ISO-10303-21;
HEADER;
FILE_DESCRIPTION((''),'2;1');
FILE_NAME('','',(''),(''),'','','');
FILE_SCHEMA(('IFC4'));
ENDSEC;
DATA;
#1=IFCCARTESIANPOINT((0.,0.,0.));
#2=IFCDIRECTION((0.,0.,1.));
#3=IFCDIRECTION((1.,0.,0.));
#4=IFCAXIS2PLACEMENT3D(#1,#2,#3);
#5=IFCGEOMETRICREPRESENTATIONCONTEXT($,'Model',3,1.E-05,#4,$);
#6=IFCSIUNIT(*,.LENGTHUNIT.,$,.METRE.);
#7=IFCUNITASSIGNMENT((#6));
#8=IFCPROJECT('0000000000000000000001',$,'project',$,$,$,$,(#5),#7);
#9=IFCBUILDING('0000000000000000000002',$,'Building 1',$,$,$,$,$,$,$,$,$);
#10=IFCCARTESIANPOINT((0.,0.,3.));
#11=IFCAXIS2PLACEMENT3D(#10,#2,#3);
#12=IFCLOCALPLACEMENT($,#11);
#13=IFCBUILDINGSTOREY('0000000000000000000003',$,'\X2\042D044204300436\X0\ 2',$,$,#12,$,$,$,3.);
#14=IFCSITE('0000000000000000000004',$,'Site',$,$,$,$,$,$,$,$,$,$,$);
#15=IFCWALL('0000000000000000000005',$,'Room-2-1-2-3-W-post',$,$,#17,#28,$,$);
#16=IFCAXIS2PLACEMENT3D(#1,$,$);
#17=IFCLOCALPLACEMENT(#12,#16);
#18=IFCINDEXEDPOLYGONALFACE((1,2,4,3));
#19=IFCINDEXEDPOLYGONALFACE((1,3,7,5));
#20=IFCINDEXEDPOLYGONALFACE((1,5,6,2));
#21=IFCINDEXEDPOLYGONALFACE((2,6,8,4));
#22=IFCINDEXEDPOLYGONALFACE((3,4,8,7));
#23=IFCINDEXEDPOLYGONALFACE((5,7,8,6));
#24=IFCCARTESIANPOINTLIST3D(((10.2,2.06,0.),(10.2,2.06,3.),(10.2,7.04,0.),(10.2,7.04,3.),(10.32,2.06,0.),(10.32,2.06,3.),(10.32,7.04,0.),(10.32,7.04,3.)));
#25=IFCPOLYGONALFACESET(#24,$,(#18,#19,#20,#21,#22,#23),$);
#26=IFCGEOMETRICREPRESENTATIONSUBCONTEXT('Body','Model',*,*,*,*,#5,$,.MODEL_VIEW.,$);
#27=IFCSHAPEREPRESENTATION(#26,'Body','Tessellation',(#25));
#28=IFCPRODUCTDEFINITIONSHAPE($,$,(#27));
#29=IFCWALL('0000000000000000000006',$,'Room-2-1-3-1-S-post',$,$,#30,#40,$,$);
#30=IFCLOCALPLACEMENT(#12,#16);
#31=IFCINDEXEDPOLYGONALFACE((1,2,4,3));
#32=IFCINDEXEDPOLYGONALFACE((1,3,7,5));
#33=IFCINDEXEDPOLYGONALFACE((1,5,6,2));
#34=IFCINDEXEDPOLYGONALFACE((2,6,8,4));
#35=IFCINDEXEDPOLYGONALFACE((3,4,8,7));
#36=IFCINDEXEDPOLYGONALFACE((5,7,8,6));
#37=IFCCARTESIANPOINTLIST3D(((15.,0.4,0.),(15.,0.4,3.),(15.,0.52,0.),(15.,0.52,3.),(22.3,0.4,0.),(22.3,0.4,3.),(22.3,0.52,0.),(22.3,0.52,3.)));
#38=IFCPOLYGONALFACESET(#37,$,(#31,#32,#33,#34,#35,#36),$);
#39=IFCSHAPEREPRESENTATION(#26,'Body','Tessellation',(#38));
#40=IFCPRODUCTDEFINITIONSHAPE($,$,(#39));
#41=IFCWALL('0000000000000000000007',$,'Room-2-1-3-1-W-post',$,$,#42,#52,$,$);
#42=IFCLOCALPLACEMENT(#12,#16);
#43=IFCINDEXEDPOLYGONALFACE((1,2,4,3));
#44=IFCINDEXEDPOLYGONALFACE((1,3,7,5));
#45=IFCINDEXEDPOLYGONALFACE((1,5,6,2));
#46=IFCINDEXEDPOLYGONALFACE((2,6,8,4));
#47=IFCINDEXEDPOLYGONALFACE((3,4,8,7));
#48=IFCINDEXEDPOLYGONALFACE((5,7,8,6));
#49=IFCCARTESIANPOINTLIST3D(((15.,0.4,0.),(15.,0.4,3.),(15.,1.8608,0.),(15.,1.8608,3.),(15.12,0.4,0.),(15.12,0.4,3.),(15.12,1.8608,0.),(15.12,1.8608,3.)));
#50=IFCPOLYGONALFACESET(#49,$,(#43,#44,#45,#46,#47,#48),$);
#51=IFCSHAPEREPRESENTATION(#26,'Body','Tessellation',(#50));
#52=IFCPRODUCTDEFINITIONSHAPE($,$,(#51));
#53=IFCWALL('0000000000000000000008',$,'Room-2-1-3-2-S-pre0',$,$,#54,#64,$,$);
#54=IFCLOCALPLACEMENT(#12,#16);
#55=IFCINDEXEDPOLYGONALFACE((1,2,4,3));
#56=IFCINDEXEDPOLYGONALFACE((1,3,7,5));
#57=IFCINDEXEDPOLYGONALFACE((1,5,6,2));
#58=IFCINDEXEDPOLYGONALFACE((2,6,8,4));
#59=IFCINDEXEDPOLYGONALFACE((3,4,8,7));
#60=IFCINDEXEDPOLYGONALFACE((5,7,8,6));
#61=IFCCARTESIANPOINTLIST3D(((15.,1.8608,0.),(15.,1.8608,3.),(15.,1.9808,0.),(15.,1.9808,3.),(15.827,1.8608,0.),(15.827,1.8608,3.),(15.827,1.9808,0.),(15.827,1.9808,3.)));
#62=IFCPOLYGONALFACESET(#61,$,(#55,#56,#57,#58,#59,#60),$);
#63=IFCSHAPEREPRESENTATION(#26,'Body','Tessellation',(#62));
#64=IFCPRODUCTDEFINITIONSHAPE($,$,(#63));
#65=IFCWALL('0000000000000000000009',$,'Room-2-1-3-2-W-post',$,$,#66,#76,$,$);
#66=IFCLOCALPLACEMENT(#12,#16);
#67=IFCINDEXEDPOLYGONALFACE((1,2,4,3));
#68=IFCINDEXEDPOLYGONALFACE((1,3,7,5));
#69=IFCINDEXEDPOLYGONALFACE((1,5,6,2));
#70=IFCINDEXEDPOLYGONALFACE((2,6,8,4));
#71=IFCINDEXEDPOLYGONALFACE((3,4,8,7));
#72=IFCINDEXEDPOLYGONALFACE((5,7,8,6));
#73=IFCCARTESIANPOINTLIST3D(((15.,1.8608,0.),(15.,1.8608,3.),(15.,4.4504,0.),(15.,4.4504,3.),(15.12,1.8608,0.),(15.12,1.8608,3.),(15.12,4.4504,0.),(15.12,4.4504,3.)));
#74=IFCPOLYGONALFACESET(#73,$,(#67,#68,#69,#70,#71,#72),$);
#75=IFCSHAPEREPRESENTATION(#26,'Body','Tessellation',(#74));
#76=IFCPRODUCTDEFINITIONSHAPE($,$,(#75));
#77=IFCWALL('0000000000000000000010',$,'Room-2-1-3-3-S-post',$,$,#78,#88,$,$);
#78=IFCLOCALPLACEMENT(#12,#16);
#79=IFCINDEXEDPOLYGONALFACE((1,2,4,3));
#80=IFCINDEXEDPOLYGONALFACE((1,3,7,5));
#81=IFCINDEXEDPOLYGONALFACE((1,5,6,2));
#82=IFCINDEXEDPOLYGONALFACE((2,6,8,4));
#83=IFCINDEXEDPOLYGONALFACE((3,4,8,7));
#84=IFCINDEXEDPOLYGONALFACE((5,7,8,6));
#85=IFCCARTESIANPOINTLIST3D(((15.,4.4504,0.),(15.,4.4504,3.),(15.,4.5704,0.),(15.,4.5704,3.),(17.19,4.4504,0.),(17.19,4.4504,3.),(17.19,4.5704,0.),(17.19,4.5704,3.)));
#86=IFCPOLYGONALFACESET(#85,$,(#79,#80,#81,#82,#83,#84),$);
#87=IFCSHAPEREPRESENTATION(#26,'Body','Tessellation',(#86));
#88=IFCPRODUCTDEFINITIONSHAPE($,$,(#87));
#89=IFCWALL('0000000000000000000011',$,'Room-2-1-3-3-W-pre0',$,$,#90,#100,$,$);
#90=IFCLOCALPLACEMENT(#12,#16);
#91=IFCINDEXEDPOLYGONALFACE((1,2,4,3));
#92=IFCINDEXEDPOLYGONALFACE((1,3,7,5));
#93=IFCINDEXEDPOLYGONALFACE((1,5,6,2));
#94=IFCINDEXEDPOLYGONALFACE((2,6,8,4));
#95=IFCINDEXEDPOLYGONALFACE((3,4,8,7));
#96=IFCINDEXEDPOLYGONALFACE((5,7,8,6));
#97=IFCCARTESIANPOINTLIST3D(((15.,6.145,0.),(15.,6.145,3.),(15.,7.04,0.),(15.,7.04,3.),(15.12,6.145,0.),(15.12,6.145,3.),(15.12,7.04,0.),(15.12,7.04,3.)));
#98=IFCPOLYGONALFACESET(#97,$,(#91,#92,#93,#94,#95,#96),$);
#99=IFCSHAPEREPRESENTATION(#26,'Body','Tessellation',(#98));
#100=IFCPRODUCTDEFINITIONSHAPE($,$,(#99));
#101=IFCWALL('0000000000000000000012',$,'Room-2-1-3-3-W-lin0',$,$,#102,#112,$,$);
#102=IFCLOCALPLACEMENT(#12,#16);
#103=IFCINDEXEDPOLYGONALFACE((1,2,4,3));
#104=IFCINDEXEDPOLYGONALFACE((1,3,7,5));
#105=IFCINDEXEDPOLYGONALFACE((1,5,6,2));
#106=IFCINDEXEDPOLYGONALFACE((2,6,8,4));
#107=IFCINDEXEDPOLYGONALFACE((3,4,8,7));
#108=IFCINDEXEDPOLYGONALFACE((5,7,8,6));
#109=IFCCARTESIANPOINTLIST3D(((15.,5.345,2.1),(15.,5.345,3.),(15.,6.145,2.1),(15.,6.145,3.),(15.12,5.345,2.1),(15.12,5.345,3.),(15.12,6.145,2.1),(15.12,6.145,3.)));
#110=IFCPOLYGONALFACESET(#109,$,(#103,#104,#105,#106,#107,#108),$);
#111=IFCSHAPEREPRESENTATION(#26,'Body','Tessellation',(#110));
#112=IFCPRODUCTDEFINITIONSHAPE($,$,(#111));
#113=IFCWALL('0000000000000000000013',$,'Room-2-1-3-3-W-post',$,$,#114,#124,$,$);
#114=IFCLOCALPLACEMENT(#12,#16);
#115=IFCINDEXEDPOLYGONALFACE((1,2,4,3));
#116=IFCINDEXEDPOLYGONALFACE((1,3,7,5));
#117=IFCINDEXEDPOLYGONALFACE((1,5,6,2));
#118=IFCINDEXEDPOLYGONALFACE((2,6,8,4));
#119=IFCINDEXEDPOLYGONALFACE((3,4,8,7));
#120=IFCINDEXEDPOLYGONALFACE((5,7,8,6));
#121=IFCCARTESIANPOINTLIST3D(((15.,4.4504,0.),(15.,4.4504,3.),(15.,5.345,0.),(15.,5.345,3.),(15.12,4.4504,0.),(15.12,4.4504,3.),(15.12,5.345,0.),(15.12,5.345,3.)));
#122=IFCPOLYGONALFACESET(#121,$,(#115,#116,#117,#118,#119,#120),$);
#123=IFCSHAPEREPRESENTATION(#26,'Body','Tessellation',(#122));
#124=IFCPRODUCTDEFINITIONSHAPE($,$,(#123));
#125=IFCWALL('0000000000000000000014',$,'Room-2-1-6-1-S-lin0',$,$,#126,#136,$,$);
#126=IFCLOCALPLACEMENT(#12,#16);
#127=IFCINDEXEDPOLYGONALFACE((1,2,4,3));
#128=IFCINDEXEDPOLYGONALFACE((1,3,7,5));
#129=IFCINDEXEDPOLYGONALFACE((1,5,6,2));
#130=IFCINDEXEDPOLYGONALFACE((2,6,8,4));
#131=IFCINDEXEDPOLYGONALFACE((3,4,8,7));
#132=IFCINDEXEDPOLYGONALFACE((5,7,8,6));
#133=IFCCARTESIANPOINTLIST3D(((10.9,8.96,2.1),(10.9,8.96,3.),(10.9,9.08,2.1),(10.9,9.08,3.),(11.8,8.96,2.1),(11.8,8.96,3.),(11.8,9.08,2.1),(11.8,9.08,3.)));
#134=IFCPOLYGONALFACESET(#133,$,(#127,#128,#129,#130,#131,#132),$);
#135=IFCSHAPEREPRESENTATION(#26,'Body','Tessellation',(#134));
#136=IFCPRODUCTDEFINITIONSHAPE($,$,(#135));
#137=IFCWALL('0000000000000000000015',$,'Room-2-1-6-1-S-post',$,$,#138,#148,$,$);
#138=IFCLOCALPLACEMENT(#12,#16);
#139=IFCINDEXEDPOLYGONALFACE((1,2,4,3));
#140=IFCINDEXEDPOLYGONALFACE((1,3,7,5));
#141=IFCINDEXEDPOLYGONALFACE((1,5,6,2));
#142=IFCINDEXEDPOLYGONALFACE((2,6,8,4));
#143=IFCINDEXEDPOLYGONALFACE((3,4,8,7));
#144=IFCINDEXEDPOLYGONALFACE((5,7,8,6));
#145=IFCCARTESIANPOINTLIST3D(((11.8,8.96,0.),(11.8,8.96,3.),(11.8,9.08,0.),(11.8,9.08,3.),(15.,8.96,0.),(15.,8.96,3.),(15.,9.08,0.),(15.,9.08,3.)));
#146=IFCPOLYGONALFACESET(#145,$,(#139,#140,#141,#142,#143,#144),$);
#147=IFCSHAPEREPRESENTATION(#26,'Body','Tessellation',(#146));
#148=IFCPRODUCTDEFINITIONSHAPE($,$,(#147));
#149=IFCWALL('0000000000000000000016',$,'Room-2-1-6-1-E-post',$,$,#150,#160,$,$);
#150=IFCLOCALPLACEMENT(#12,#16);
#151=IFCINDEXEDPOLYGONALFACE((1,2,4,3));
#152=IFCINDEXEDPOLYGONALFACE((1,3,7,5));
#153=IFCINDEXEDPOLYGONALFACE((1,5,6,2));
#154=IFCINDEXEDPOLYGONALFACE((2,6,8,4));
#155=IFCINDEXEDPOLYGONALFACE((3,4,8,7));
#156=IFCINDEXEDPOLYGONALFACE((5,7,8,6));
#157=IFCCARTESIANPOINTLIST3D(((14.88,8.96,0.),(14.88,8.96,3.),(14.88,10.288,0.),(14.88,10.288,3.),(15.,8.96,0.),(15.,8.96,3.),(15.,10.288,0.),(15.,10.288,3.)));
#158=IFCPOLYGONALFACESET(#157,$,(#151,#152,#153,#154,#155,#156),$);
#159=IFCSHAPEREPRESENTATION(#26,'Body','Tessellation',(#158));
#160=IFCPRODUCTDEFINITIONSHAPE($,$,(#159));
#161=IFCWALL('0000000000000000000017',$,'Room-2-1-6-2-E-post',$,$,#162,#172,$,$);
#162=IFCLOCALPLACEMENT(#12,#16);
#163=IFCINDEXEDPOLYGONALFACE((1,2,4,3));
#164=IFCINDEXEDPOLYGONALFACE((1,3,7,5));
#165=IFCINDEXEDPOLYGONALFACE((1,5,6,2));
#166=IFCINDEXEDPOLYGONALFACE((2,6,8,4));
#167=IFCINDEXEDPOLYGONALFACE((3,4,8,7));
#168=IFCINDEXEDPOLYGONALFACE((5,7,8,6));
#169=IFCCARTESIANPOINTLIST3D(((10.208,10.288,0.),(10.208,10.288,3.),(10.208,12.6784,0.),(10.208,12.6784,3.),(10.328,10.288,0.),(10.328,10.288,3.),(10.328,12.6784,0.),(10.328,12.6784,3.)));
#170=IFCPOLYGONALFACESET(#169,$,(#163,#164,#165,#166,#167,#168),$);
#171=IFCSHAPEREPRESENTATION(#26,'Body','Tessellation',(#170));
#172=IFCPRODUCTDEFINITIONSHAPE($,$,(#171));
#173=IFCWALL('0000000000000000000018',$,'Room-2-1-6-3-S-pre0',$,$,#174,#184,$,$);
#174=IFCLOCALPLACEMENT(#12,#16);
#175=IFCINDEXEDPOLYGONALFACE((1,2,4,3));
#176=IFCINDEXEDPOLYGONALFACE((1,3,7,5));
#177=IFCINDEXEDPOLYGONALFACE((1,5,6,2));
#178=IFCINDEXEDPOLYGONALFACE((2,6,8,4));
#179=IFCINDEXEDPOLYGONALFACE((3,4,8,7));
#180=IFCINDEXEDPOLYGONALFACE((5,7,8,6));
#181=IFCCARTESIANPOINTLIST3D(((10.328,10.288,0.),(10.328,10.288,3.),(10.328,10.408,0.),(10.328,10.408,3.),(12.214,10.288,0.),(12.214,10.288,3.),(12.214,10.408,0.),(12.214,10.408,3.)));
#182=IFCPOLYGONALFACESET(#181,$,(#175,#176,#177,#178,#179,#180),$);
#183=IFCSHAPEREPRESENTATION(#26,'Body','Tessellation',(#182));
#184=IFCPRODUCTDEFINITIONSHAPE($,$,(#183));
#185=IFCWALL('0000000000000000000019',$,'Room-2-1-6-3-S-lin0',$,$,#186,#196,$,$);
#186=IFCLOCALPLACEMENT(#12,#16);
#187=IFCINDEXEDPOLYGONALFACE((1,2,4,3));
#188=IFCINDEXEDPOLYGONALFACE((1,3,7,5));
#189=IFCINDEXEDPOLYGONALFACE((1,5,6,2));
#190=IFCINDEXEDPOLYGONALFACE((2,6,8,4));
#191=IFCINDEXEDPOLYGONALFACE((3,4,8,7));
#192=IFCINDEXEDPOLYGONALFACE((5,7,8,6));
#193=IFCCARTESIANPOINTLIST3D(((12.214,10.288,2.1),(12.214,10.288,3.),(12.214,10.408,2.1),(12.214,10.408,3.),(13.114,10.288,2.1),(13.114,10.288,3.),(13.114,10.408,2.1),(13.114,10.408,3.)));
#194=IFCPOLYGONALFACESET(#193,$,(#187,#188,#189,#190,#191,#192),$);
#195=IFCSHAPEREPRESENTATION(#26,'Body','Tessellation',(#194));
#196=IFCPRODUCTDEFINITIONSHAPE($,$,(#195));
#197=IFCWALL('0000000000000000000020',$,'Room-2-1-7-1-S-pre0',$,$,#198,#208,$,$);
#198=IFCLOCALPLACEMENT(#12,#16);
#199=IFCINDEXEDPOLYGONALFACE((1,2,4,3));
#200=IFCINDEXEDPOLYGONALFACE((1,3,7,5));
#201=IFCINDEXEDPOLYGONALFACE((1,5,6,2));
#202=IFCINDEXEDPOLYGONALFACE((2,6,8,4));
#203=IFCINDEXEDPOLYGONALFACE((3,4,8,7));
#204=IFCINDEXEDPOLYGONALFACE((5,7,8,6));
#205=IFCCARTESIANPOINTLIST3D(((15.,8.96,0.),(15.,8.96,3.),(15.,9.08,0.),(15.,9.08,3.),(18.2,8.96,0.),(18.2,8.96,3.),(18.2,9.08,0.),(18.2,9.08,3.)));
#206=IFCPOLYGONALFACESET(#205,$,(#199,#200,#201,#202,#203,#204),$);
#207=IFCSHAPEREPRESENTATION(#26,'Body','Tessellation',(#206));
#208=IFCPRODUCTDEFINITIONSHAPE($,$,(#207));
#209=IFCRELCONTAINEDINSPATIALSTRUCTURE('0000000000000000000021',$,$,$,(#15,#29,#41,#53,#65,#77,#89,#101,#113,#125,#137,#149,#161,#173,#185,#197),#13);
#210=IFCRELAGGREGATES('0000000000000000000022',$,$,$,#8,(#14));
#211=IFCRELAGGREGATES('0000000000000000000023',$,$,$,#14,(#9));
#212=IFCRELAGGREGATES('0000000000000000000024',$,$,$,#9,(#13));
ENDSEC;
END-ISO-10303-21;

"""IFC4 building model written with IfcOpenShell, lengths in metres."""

from ifc_helpers import new_model, si_unit, frame, origin_with_axes, place, context, subcontext, project, spatial, indexed_curve, outline, extrude, element, save


model = new_model("IFC4")

# Units and contexts
model_context = context("Model", 3, precision=1e-05, world=origin_with_axes())
body_context = subcontext(model_context, "Body", "Model", "MODEL_VIEW")
ifc_project = project(units=[si_unit("LENGTHUNIT", "METRE")], contexts=[model_context])

# Site, building, storey
site = spatial("IfcSite", under=ifc_project, Name="Site")
building = spatial("IfcBuilding", under=site, Name="Building 1")
storey_placement = place(None, frame((0.0, 0.0, 3.0), z_axis=(0.0, 0.0, 1.0), x_axis=(1.0, 0.0, 0.0)))
storey = spatial("IfcBuildingStorey", under=building, at=storey_placement, Name="Этаж 2", Elevation=3.0)

# Walls
wall_1_placement = place(storey_placement, frame((10.2, 7.04, 0.0), z_axis=(0.0, 0.0, 1.0), x_axis=(0.0, -1.0, 0.0)))
element("IfcWall", 1, at=wall_1_placement, inside=storey, Name="Room-2-1-2-3-W-post", context=body_context, shape_type="SweptSolid", body=[
    extrude(outline(indexed_curve([(0.0, 0.0), (0.0, 0.12), (4.98, 0.12), (4.98, 0.0), (0.0, 0.0)], self_intersect=False)), origin_with_axes(), (0.0, 0.0, 1.0), 3.0),
])
wall_2_placement = place(storey_placement, frame((15.0, 0.4, 0.0), z_axis=(0.0, 0.0, 1.0), x_axis=(1.0, 0.0, 0.0)))
element("IfcWall", 2, at=wall_2_placement, inside=storey, Name="Room-2-1-3-1-S-post", context=body_context, shape_type="SweptSolid", body=[
    extrude(outline(indexed_curve([(0.0, 0.0), (0.0, 0.12), (7.3, 0.12), (7.3, 0.0), (0.0, 0.0)], self_intersect=False)), origin_with_axes(), (0.0, 0.0, 1.0), 3.0),
])
wall_3_placement = place(storey_placement, frame((15.0, 1.8608, 0.0), z_axis=(0.0, 0.0, 1.0), x_axis=(0.0, -1.0, 0.0)))
element("IfcWall", 3, at=wall_3_placement, inside=storey, Name="Room-2-1-3-1-W-post", context=body_context, shape_type="SweptSolid", body=[
    extrude(outline(indexed_curve([(0.0, 0.0), (0.0, 0.12), (1.4608, 0.12), (1.4608, 0.0), (0.0, 0.0)], self_intersect=False)), origin_with_axes(), (0.0, 0.0, 1.0), 3.0),
])
wall_4_placement = place(storey_placement, frame((15.0, 1.8608, 0.0), z_axis=(0.0, 0.0, 1.0), x_axis=(1.0, 0.0, 0.0)))
element("IfcWall", 4, at=wall_4_placement, inside=storey, Name="Room-2-1-3-2-S-pre0", context=body_context, shape_type="SweptSolid", body=[
    extrude(outline(indexed_curve([(0.0, 0.0), (0.0, 0.12), (0.827, 0.12), (0.827, 0.0), (0.0, 0.0)], self_intersect=False)), origin_with_axes(), (0.0, 0.0, 1.0), 3.0),
])
wall_5_placement = place(storey_placement, frame((15.0, 4.4504, 0.0), z_axis=(0.0, 0.0, 1.0), x_axis=(0.0, -1.0, 0.0)))
element("IfcWall", 5, at=wall_5_placement, inside=storey, Name="Room-2-1-3-2-W-post", context=body_context, shape_type="SweptSolid", body=[
    extrude(outline(indexed_curve([(0.0, 0.0), (0.0, 0.12), (2.5896, 0.12), (2.5896, 0.0), (0.0, 0.0)], self_intersect=False)), origin_with_axes(), (0.0, 0.0, 1.0), 3.0),
])
wall_6_placement = place(storey_placement, frame((15.0, 4.4504, 0.0), z_axis=(0.0, 0.0, 1.0), x_axis=(1.0, 0.0, 0.0)))
element("IfcWall", 6, at=wall_6_placement, inside=storey, Name="Room-2-1-3-3-S-post", context=body_context, shape_type="SweptSolid", body=[
    extrude(outline(indexed_curve([(0.0, 0.0), (0.0, 0.12), (2.19, 0.12), (2.19, 0.0), (0.0, 0.0)], self_intersect=False)), origin_with_axes(), (0.0, 0.0, 1.0), 3.0),
])
wall_7_placement = place(storey_placement, frame((15.0, 7.04, 0.0), z_axis=(0.0, 0.0, 1.0), x_axis=(0.0, -1.0, 0.0)))
element("IfcWall", 7, at=wall_7_placement, inside=storey, Name="Room-2-1-3-3-W-pre0", context=body_context, shape_type="SweptSolid", body=[
    extrude(outline(indexed_curve([(0.0, 0.0), (0.0, 0.12), (0.895, 0.12), (0.895, 0.0), (0.0, 0.0)], self_intersect=False)), origin_with_axes(), (0.0, 0.0, 1.0), 3.0),
])
wall_8_placement = place(storey_placement, frame((15.0, 6.145, 2.1), z_axis=(0.0, 0.0, 1.0), x_axis=(0.0, -1.0, 0.0)))
element("IfcWall", 8, at=wall_8_placement, inside=storey, Name="Room-2-1-3-3-W-lin0", context=body_context, shape_type="SweptSolid", body=[
    extrude(outline(indexed_curve([(0.0, 0.0), (0.0, 0.12), (0.8, 0.12), (0.8, 0.0), (0.0, 0.0)], self_intersect=False)), origin_with_axes(), (0.0, 0.0, 1.0), 0.9),
])
wall_9_placement = place(storey_placement, frame((15.0, 5.345, 0.0), z_axis=(0.0, 0.0, 1.0), x_axis=(0.0, -1.0, 0.0)))
element("IfcWall", 9, at=wall_9_placement, inside=storey, Name="Room-2-1-3-3-W-post", context=body_context, shape_type="SweptSolid", body=[
    extrude(outline(indexed_curve([(0.0, 0.0), (0.0, 0.12), (0.8946, 0.12), (0.8946, 0.0), (0.0, 0.0)], self_intersect=False)), origin_with_axes(), (0.0, 0.0, 1.0), 3.0),
])
wall_10_placement = place(storey_placement, frame((10.9, 8.96, 2.1), z_axis=(0.0, 0.0, 1.0), x_axis=(1.0, 0.0, 0.0)))
element("IfcWall", 10, at=wall_10_placement, inside=storey, Name="Room-2-1-6-1-S-lin0", context=body_context, shape_type="SweptSolid", body=[
    extrude(outline(indexed_curve([(0.0, 0.0), (0.0, 0.12), (0.9, 0.12), (0.9, 0.0), (0.0, 0.0)], self_intersect=False)), origin_with_axes(), (0.0, 0.0, 1.0), 0.9),
])
wall_11_placement = place(storey_placement, frame((11.8, 8.96, 0.0), z_axis=(0.0, 0.0, 1.0), x_axis=(1.0, 0.0, 0.0)))
element("IfcWall", 11, at=wall_11_placement, inside=storey, Name="Room-2-1-6-1-S-post", context=body_context, shape_type="SweptSolid", body=[
    extrude(outline(indexed_curve([(0.0, 0.0), (0.0, 0.12), (3.2, 0.12), (3.2, 0.0), (0.0, 0.0)], self_intersect=False)), origin_with_axes(), (0.0, 0.0, 1.0), 3.0),
])
wall_12_placement = place(storey_placement, frame((15.0, 8.96, 0.0), z_axis=(0.0, 0.0, 1.0), x_axis=(0.0, 1.0, 0.0)))
element("IfcWall", 12, at=wall_12_placement, inside=storey, Name="Room-2-1-6-1-E-post", context=body_context, shape_type="SweptSolid", body=[
    extrude(outline(indexed_curve([(0.0, 0.0), (0.0, 0.12), (1.328, 0.12), (1.328, 0.0), (0.0, 0.0)], self_intersect=False)), origin_with_axes(), (0.0, 0.0, 1.0), 3.0),
])
wall_13_placement = place(storey_placement, frame((10.328, 10.288, 0.0), z_axis=(0.0, 0.0, 1.0), x_axis=(0.0, 1.0, 0.0)))
element("IfcWall", 13, at=wall_13_placement, inside=storey, Name="Room-2-1-6-2-E-post", context=body_context, shape_type="SweptSolid", body=[
    extrude(outline(indexed_curve([(0.0, 0.0), (0.0, 0.12), (2.3904, 0.12), (2.3904, 0.0), (0.0, 0.0)], self_intersect=False)), origin_with_axes(), (0.0, 0.0, 1.0), 3.0),
])
wall_14_placement = place(storey_placement, frame((10.328, 10.288, 0.0), z_axis=(0.0, 0.0, 1.0), x_axis=(1.0, 0.0, 0.0)))
element("IfcWall", 14, at=wall_14_placement, inside=storey, Name="Room-2-1-6-3-S-pre0", context=body_context, shape_type="SweptSolid", body=[
    extrude(outline(indexed_curve([(0.0, 0.0), (0.0, 0.12), (1.886, 0.12), (1.886, 0.0), (0.0, 0.0)], self_intersect=False)), origin_with_axes(), (0.0, 0.0, 1.0), 3.0),
])
wall_15_placement = place(storey_placement, frame((12.214, 10.288, 2.1), z_axis=(0.0, 0.0, 1.0), x_axis=(1.0, 0.0, 0.0)))
element("IfcWall", 15, at=wall_15_placement, inside=storey, Name="Room-2-1-6-3-S-lin0", context=body_context, shape_type="SweptSolid", body=[
    extrude(outline(indexed_curve([(0.0, 0.0), (0.0, 0.12), (0.9, 0.12), (0.9, 0.0), (0.0, 0.0)], self_intersect=False)), origin_with_axes(), (0.0, 0.0, 1.0), 0.9),
])
wall_16_placement = place(storey_placement, frame((15.0, 8.96, 0.0), z_axis=(0.0, 0.0, 1.0), x_axis=(1.0, 0.0, 0.0)))
element("IfcWall", 16, at=wall_16_placement, inside=storey, Name="Room-2-1-7-1-S-pre0", context=body_context, shape_type="SweptSolid", body=[
    extrude(outline(indexed_curve([(0.0, 0.0), (0.0, 0.12), (3.2, 0.12), (3.2, 0.0), (0.0, 0.0)], self_intersect=False)), origin_with_axes(), (0.0, 0.0, 1.0), 3.0),
])

save(model, "model.ifc")
